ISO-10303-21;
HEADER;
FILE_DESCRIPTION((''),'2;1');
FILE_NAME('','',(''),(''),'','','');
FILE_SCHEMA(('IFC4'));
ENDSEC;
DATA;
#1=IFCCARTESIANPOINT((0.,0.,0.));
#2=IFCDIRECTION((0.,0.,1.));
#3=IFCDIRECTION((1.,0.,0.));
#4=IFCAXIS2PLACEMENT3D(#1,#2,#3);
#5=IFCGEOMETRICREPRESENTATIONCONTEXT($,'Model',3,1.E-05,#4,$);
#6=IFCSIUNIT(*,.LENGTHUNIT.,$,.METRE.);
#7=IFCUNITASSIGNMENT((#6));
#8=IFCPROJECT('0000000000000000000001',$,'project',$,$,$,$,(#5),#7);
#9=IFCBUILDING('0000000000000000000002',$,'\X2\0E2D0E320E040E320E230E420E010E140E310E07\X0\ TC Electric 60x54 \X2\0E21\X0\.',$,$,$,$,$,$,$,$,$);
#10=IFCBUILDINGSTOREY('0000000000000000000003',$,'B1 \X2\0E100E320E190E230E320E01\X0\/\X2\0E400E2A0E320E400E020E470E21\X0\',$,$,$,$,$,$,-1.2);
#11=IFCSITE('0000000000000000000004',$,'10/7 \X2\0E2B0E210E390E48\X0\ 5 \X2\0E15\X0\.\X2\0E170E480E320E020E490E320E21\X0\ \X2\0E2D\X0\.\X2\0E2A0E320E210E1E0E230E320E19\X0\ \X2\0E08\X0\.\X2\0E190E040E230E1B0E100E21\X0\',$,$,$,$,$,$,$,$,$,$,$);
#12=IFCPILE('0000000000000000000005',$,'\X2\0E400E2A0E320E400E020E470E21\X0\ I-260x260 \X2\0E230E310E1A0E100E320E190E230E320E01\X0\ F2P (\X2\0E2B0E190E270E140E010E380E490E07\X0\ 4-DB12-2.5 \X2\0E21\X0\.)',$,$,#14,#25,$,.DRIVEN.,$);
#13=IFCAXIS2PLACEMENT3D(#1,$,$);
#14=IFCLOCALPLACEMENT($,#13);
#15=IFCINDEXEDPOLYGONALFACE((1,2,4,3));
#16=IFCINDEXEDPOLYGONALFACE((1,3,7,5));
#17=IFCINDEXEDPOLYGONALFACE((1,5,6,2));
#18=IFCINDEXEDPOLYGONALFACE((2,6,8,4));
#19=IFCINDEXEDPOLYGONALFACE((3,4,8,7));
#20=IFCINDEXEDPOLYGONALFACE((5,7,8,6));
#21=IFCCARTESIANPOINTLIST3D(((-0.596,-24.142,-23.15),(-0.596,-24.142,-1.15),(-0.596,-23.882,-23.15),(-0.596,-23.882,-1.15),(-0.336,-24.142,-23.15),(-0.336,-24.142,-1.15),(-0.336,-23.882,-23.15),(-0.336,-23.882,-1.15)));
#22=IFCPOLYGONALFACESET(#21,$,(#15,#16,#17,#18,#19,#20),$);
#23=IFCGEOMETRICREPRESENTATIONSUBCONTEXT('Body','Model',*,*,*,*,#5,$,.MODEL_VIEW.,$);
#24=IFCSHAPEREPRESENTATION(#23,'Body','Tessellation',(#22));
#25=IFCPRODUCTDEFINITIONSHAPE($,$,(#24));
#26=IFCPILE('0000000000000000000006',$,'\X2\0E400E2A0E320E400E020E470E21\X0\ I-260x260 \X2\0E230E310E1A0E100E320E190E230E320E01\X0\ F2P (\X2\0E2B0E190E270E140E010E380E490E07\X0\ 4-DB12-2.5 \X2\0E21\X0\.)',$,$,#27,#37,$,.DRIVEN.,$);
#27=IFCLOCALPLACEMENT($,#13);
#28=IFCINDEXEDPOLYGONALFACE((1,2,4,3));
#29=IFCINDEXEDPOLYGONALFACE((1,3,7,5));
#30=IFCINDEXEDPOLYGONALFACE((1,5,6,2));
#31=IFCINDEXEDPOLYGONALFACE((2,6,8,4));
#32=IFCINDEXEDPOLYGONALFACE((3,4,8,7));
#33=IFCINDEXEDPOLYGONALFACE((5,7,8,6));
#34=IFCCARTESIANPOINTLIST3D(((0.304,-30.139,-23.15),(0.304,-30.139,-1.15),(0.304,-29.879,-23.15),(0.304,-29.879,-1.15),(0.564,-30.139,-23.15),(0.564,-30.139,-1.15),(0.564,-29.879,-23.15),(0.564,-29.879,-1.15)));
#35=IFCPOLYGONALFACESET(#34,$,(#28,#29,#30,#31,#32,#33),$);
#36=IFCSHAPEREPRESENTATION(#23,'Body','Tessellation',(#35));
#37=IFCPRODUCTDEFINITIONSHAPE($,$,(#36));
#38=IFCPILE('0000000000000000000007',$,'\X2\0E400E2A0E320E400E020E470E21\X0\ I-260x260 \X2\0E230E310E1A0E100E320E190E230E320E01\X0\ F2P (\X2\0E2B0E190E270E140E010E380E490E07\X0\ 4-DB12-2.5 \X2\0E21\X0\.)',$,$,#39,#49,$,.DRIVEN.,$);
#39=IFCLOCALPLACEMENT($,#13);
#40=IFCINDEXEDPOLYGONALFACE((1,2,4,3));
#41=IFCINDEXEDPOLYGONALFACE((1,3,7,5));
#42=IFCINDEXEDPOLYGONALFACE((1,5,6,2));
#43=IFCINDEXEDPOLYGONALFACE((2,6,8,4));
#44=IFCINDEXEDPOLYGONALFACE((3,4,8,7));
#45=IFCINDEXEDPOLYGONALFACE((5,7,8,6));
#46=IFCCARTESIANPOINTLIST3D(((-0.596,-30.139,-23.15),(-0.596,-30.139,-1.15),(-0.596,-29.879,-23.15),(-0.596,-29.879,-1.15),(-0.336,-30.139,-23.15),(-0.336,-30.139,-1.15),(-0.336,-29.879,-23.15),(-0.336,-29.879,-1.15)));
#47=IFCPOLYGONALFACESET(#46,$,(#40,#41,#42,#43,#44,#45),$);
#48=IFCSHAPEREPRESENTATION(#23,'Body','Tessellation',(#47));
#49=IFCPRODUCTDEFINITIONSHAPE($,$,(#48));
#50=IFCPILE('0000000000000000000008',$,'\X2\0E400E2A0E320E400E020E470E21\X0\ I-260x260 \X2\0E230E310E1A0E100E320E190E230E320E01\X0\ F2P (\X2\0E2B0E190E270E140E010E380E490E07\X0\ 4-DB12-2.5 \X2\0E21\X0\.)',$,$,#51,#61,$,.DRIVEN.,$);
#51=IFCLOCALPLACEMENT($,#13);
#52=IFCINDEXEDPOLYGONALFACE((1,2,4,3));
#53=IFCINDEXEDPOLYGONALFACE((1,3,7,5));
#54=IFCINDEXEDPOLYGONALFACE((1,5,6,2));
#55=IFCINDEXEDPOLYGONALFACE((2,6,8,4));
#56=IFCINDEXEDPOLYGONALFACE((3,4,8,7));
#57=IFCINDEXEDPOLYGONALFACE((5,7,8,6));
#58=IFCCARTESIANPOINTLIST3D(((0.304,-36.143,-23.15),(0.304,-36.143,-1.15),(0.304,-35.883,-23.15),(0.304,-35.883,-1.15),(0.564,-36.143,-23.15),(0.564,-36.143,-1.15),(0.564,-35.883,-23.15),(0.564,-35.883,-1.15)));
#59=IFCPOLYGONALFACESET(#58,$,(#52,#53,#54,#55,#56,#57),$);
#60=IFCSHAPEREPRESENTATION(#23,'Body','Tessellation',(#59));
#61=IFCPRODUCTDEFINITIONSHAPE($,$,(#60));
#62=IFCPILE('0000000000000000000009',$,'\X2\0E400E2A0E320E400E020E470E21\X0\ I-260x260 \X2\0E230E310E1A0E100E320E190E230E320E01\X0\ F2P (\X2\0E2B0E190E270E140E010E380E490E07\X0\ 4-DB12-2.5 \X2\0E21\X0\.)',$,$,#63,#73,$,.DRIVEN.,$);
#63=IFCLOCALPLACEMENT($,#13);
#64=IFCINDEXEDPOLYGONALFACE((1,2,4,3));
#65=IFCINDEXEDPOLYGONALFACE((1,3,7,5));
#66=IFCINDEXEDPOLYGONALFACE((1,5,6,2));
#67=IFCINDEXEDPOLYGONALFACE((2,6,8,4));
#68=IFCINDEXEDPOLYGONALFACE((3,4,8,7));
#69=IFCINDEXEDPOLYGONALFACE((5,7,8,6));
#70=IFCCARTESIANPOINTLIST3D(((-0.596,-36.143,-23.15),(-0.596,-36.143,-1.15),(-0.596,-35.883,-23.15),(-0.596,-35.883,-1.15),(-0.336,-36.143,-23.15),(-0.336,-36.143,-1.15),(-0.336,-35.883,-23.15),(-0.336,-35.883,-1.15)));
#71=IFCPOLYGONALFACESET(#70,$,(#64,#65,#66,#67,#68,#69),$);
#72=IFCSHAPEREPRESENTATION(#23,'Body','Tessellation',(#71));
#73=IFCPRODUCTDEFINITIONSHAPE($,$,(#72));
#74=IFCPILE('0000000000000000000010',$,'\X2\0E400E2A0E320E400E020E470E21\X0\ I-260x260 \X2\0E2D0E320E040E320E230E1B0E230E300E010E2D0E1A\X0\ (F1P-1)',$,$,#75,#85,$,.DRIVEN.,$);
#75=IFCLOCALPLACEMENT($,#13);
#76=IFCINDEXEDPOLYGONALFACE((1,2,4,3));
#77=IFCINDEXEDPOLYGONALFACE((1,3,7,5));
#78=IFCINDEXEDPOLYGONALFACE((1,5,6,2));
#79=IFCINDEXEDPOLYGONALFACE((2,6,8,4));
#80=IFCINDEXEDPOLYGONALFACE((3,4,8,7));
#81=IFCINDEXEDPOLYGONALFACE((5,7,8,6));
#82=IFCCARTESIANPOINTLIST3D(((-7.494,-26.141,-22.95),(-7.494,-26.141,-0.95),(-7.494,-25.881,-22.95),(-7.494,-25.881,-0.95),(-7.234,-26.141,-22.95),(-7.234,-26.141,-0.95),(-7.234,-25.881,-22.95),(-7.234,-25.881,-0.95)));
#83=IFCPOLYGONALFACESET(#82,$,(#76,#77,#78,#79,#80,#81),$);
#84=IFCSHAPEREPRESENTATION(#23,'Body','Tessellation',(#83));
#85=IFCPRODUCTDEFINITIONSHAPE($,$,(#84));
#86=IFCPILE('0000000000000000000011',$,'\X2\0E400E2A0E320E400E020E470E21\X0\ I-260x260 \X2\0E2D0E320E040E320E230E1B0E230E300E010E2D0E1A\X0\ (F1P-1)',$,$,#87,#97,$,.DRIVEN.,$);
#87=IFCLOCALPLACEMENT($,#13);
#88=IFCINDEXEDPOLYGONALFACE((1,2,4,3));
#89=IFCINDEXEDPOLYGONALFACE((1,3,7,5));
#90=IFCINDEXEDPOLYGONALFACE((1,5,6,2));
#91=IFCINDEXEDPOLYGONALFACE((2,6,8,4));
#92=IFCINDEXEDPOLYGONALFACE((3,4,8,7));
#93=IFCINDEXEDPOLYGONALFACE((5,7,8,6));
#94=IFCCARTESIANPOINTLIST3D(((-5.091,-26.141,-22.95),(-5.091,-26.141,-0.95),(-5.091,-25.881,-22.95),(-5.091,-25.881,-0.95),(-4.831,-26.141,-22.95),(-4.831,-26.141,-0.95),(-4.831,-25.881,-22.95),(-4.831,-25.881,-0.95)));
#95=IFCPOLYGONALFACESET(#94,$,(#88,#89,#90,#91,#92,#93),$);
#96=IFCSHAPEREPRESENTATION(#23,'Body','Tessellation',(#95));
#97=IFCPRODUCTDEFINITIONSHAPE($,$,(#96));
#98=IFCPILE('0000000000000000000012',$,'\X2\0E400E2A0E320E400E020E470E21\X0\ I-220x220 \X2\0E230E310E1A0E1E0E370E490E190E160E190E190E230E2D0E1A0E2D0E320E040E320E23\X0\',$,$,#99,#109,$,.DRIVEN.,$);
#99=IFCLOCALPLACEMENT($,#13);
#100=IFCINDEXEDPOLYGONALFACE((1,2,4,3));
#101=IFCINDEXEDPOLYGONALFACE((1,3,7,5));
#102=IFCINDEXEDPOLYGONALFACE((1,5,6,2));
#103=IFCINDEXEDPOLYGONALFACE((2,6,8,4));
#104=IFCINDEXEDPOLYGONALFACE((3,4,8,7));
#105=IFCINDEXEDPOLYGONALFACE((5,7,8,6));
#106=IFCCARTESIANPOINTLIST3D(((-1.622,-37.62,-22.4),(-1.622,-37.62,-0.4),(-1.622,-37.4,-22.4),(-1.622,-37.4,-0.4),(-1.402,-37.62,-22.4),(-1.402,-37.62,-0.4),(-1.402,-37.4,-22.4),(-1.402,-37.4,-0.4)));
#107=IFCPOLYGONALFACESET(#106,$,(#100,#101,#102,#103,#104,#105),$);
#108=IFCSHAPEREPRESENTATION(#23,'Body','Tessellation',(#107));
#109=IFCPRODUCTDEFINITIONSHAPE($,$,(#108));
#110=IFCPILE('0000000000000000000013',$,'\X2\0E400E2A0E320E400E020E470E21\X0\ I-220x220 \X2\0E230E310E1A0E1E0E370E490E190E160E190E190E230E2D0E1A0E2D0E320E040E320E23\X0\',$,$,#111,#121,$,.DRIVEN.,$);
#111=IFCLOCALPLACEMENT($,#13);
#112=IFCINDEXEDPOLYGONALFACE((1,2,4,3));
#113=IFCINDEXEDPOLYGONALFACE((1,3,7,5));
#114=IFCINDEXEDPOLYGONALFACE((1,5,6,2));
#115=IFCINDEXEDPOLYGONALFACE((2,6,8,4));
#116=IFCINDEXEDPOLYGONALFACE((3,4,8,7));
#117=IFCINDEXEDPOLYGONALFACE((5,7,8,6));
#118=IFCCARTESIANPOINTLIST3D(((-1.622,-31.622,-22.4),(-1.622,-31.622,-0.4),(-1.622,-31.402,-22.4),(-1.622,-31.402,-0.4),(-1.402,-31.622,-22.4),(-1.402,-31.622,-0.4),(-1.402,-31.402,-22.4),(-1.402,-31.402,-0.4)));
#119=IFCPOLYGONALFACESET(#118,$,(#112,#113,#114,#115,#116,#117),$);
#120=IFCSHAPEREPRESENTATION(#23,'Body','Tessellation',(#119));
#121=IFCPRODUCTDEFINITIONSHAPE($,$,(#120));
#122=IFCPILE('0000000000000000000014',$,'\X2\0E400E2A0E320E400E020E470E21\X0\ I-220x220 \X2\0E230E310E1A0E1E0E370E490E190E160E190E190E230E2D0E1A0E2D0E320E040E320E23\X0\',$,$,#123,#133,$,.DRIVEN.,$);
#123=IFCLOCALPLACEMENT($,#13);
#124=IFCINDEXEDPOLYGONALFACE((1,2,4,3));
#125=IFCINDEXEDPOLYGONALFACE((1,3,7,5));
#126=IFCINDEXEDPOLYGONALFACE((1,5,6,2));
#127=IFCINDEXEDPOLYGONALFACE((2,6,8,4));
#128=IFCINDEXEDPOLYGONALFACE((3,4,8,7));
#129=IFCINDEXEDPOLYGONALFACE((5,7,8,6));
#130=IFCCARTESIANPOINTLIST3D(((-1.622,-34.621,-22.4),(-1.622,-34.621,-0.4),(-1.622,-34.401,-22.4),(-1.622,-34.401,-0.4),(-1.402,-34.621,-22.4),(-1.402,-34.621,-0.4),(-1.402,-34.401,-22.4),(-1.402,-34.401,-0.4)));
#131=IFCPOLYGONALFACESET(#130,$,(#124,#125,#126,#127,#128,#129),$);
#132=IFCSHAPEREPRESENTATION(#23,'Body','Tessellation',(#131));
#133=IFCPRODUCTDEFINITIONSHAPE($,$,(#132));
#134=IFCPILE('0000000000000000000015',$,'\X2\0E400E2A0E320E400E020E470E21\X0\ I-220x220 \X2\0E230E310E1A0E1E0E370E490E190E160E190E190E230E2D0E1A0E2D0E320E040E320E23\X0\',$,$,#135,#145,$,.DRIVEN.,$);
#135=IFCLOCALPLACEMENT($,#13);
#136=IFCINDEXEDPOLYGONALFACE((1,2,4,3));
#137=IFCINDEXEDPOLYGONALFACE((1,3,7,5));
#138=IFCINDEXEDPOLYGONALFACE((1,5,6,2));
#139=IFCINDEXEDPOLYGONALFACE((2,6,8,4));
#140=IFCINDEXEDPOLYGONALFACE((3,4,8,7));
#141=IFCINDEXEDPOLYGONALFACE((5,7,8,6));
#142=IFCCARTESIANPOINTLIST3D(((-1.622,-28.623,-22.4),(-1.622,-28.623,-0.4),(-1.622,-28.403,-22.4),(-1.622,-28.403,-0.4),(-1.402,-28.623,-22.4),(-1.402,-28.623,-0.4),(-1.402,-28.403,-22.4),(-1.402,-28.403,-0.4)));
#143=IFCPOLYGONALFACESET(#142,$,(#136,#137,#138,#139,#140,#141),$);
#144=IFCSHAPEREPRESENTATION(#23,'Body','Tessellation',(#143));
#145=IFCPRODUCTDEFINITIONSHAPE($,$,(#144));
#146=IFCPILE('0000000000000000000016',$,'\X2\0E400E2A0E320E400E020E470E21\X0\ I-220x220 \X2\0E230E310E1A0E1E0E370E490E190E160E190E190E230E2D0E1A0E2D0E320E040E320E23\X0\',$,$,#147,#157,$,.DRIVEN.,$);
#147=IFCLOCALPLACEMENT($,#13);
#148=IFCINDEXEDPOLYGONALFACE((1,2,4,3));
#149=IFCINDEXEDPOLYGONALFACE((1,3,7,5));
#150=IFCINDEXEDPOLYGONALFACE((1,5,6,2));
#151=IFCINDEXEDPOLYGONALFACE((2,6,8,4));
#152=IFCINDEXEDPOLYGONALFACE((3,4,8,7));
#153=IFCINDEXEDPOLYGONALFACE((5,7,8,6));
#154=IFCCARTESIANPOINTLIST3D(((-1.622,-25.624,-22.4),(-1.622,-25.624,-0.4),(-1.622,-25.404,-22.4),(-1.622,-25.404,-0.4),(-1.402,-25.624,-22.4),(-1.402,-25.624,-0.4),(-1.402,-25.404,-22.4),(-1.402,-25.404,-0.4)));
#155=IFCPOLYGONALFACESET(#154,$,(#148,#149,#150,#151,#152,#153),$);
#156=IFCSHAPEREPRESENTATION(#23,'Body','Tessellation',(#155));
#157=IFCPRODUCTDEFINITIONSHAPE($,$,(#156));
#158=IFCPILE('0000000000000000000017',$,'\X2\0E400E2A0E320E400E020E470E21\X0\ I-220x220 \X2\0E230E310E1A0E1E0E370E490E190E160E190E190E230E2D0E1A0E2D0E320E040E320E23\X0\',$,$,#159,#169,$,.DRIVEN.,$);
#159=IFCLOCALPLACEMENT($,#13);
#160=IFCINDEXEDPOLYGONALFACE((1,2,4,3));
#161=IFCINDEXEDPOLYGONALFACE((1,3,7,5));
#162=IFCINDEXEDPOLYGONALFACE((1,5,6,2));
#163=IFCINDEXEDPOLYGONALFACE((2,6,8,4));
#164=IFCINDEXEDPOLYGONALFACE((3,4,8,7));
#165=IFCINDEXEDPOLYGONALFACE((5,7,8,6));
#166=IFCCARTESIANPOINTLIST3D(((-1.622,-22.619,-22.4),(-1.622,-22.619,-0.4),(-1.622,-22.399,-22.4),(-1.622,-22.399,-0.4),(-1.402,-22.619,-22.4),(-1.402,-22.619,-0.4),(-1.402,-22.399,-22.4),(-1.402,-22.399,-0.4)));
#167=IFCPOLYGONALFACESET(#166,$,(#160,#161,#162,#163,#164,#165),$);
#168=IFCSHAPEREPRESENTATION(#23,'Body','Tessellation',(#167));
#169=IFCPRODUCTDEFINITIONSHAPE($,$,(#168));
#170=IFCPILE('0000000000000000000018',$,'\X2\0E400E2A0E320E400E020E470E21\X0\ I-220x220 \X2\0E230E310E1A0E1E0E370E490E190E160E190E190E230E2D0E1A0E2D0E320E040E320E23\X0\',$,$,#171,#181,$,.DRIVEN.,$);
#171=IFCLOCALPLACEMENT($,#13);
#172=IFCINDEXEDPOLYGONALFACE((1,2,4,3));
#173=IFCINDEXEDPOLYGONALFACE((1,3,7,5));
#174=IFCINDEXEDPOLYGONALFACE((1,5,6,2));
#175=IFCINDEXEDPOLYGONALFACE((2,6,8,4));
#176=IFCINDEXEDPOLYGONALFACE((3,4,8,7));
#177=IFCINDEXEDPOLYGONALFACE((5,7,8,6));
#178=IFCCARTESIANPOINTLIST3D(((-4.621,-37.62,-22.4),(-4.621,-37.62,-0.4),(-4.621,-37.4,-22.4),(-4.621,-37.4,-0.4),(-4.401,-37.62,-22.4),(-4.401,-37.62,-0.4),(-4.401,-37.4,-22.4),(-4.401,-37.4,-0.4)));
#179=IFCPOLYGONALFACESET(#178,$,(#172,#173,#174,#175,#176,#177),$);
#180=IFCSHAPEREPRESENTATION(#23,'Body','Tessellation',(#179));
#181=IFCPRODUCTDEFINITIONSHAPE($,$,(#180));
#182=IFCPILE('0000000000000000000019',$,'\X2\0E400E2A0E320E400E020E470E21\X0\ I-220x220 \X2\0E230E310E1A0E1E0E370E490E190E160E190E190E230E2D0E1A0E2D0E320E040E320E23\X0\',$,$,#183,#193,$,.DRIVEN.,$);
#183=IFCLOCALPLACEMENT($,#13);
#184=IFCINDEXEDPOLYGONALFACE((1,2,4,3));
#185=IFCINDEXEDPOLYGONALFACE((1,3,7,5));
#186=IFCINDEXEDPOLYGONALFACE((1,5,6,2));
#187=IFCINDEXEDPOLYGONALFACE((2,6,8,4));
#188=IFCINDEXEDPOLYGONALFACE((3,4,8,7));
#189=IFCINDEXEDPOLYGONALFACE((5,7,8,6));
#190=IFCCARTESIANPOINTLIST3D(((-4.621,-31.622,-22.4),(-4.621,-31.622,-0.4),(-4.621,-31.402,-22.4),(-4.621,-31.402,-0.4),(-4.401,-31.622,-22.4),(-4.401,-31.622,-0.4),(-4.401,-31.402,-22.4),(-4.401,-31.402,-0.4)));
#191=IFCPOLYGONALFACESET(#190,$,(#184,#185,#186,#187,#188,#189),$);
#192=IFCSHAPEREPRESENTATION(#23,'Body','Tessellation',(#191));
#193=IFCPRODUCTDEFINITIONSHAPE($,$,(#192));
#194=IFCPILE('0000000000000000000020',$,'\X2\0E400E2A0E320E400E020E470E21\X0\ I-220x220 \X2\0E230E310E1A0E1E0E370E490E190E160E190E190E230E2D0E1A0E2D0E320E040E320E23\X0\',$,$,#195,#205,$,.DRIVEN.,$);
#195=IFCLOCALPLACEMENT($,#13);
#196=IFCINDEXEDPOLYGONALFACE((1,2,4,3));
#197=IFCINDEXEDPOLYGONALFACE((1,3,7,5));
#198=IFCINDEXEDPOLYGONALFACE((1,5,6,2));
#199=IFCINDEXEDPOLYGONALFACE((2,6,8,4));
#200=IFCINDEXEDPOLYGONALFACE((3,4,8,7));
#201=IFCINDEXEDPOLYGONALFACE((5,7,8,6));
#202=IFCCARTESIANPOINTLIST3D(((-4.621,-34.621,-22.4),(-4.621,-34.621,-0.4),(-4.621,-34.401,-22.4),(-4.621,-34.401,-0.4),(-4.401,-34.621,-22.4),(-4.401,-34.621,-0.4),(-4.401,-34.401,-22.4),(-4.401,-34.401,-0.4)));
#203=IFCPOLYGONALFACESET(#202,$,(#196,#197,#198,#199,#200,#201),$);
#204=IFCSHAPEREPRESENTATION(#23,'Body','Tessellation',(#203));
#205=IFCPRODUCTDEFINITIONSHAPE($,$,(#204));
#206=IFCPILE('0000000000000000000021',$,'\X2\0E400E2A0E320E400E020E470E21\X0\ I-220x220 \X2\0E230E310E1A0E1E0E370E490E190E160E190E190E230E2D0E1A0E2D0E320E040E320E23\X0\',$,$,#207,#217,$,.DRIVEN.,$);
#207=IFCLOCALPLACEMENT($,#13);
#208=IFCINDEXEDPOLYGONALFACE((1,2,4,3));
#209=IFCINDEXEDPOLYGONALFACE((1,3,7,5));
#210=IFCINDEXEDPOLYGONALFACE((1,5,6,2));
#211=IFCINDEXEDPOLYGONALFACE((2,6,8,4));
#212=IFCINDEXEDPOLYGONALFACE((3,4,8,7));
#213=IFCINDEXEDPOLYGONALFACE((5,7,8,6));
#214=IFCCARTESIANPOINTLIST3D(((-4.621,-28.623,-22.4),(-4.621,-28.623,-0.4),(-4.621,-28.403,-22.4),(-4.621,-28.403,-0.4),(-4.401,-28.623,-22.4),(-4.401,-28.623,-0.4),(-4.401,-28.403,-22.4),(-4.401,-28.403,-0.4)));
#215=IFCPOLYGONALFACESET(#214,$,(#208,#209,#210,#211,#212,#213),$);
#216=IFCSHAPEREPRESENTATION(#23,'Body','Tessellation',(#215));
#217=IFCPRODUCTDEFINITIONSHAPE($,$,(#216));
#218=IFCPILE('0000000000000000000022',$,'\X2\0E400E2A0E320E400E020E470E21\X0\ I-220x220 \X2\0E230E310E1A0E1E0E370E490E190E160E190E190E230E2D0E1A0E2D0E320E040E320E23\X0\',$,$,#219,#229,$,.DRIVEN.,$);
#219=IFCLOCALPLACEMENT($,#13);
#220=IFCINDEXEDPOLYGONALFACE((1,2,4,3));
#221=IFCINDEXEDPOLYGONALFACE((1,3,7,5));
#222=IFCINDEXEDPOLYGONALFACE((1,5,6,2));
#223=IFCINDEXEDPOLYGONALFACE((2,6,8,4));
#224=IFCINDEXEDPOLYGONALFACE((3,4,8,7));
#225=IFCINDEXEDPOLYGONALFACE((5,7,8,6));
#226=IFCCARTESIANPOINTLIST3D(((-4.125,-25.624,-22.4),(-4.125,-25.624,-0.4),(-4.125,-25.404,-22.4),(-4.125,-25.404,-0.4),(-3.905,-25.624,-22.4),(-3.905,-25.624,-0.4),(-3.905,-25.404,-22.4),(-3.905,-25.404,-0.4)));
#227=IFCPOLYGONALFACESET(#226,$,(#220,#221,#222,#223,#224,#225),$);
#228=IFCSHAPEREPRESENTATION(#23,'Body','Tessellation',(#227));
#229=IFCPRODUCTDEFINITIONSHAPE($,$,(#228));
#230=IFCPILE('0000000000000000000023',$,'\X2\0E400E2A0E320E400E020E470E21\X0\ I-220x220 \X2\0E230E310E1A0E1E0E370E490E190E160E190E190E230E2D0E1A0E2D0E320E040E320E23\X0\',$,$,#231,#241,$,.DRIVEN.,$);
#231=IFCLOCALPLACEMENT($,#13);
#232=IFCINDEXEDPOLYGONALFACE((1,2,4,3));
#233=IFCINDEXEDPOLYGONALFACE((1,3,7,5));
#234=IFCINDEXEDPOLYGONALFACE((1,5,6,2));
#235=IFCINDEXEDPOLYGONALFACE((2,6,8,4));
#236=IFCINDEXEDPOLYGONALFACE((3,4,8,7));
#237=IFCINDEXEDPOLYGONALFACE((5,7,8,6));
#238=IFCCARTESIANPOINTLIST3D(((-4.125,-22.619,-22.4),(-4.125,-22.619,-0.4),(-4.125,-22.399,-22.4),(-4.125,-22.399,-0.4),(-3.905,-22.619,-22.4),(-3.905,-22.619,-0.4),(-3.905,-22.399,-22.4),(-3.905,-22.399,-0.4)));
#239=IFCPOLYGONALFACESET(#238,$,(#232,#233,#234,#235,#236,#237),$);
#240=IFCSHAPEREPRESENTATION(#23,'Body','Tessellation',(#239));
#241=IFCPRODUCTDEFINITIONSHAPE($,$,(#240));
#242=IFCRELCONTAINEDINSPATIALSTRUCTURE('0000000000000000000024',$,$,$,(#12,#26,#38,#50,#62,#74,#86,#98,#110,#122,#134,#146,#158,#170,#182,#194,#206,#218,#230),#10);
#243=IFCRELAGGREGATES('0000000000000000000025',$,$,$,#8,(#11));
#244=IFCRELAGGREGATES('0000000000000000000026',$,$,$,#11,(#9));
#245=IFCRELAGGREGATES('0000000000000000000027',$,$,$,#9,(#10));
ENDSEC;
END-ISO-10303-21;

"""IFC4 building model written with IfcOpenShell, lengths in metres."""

from ifc_helpers import new_model, si_unit, frame, origin, origin_with_axes, origin_2d, place, context, subcontext, project, spatial, rectangle, extrude, element, save


model = new_model("IFC4")

# Units and contexts
model_context = context("Model", 3, precision=1e-05, world=origin_with_axes())
body_context = subcontext(model_context, "Body", "Model", "MODEL_VIEW")
ifc_project = project(units=[si_unit("LENGTHUNIT", "METRE")], contexts=[model_context])

# Site, building, storey
site = spatial("IfcSite", under=ifc_project, Name="10/7 หมู่ 5 ต.ท่าข้าม อ.สามพราน จ.นครปฐม")
building = spatial("IfcBuilding", under=site, Name="อาคารโกดัง TC Electric 60x54 ม.")
storey = spatial("IfcBuildingStorey", under=building, Name="B1 ฐานราก/เสาเข็ม", Elevation=-1.2)

# Piles
for number, where, z_axis, x_axis, name in (
    (1, (-0.466, -24.012, -23.15), (0.0, 0.0, 1.0), (1.0, 0.0, 0.0), "เสาเข็ม I-260x260 รับฐานราก F2P (หนวดกุ้ง 4-DB12-2.5 ม.)"),
    (2, (0.434, -30.009, -23.15), (0.0, 0.0, 1.0), (1.0, 0.0, 0.0), "เสาเข็ม I-260x260 รับฐานราก F2P (หนวดกุ้ง 4-DB12-2.5 ม.)"),
    (3, (-0.466, -30.009, -23.15), (0.0, 0.0, 1.0), (1.0, 0.0, 0.0), "เสาเข็ม I-260x260 รับฐานราก F2P (หนวดกุ้ง 4-DB12-2.5 ม.)"),
    (4, (0.434, -36.013, -23.15), (0.0, 0.0, 1.0), (1.0, 0.0, 0.0), "เสาเข็ม I-260x260 รับฐานราก F2P (หนวดกุ้ง 4-DB12-2.5 ม.)"),
    (5, (-0.466, -36.013, -23.15), (0.0, 0.0, 1.0), (1.0, 0.0, 0.0), "เสาเข็ม I-260x260 รับฐานราก F2P (หนวดกุ้ง 4-DB12-2.5 ม.)"),
    (6, (-7.364, -26.011, -22.95), (0.0, 0.0, 1.0), (1.0, 0.0, 0.0), "เสาเข็ม I-260x260 อาคารประกอบ (F1P-1)"),
    (7, (-4.961, -26.011, -22.95), (0.0, 0.0, 1.0), (1.0, 0.0, 0.0), "เสาเข็ม I-260x260 อาคารประกอบ (F1P-1)"),
):
    element("IfcPile", number, at=place(None, frame(where, z_axis=z_axis, x_axis=x_axis)), inside=storey, Name=name, PredefinedType="DRIVEN", context=body_context, shape_type="SweptSolid", body=[
        extrude(rectangle(XDim=0.26, YDim=0.26, at=origin_2d()), origin(), (0.0, 0.0, 1.0), 22.0),
    ])
for number, where, z_axis, x_axis, name in (
    (8, (-1.512, -37.51, -22.4), (0.0, 0.0, 1.0), (1.0, 0.0, 0.0), "เสาเข็ม I-220x220 รับพื้นถนนรอบอาคาร"),
    (9, (-1.512, -31.512, -22.4), (0.0, 0.0, 1.0), (1.0, 0.0, 0.0), "เสาเข็ม I-220x220 รับพื้นถนนรอบอาคาร"),
    (10, (-1.512, -34.511, -22.4), (0.0, 0.0, 1.0), (1.0, 0.0, 0.0), "เสาเข็ม I-220x220 รับพื้นถนนรอบอาคาร"),
    (11, (-1.512, -28.513, -22.4), (0.0, 0.0, 1.0), (1.0, 0.0, 0.0), "เสาเข็ม I-220x220 รับพื้นถนนรอบอาคาร"),
    (12, (-1.512, -25.514, -22.4), (0.0, 0.0, 1.0), (1.0, 0.0, 0.0), "เสาเข็ม I-220x220 รับพื้นถนนรอบอาคาร"),
    (13, (-1.512, -22.509, -22.4), (0.0, 0.0, 1.0), (1.0, 0.0, 0.0), "เสาเข็ม I-220x220 รับพื้นถนนรอบอาคาร"),
    (14, (-4.511, -37.51, -22.4), (0.0, 0.0, 1.0), (1.0, 0.0, 0.0), "เสาเข็ม I-220x220 รับพื้นถนนรอบอาคาร"),
    (15, (-4.511, -31.512, -22.4), (0.0, 0.0, 1.0), (1.0, 0.0, 0.0), "เสาเข็ม I-220x220 รับพื้นถนนรอบอาคาร"),
    (16, (-4.511, -34.511, -22.4), (0.0, 0.0, 1.0), (1.0, 0.0, 0.0), "เสาเข็ม I-220x220 รับพื้นถนนรอบอาคาร"),
    (17, (-4.511, -28.513, -22.4), (0.0, 0.0, 1.0), (1.0, 0.0, 0.0), "เสาเข็ม I-220x220 รับพื้นถนนรอบอาคาร"),
    (18, (-4.015, -25.514, -22.4), (0.0, 0.0, 1.0), (1.0, 0.0, 0.0), "เสาเข็ม I-220x220 รับพื้นถนนรอบอาคาร"),
    (19, (-4.015, -22.509, -22.4), (0.0, 0.0, 1.0), (1.0, 0.0, 0.0), "เสาเข็ม I-220x220 รับพื้นถนนรอบอาคาร"),
):
    element("IfcPile", number, at=place(None, frame(where, z_axis=z_axis, x_axis=x_axis)), inside=storey, Name=name, PredefinedType="DRIVEN", context=body_context, shape_type="SweptSolid", body=[
        extrude(rectangle(XDim=0.22, YDim=0.22, at=origin_2d()), origin(), (0.0, 0.0, 1.0), 22.0),
    ])

save(model, "model.ifc")
